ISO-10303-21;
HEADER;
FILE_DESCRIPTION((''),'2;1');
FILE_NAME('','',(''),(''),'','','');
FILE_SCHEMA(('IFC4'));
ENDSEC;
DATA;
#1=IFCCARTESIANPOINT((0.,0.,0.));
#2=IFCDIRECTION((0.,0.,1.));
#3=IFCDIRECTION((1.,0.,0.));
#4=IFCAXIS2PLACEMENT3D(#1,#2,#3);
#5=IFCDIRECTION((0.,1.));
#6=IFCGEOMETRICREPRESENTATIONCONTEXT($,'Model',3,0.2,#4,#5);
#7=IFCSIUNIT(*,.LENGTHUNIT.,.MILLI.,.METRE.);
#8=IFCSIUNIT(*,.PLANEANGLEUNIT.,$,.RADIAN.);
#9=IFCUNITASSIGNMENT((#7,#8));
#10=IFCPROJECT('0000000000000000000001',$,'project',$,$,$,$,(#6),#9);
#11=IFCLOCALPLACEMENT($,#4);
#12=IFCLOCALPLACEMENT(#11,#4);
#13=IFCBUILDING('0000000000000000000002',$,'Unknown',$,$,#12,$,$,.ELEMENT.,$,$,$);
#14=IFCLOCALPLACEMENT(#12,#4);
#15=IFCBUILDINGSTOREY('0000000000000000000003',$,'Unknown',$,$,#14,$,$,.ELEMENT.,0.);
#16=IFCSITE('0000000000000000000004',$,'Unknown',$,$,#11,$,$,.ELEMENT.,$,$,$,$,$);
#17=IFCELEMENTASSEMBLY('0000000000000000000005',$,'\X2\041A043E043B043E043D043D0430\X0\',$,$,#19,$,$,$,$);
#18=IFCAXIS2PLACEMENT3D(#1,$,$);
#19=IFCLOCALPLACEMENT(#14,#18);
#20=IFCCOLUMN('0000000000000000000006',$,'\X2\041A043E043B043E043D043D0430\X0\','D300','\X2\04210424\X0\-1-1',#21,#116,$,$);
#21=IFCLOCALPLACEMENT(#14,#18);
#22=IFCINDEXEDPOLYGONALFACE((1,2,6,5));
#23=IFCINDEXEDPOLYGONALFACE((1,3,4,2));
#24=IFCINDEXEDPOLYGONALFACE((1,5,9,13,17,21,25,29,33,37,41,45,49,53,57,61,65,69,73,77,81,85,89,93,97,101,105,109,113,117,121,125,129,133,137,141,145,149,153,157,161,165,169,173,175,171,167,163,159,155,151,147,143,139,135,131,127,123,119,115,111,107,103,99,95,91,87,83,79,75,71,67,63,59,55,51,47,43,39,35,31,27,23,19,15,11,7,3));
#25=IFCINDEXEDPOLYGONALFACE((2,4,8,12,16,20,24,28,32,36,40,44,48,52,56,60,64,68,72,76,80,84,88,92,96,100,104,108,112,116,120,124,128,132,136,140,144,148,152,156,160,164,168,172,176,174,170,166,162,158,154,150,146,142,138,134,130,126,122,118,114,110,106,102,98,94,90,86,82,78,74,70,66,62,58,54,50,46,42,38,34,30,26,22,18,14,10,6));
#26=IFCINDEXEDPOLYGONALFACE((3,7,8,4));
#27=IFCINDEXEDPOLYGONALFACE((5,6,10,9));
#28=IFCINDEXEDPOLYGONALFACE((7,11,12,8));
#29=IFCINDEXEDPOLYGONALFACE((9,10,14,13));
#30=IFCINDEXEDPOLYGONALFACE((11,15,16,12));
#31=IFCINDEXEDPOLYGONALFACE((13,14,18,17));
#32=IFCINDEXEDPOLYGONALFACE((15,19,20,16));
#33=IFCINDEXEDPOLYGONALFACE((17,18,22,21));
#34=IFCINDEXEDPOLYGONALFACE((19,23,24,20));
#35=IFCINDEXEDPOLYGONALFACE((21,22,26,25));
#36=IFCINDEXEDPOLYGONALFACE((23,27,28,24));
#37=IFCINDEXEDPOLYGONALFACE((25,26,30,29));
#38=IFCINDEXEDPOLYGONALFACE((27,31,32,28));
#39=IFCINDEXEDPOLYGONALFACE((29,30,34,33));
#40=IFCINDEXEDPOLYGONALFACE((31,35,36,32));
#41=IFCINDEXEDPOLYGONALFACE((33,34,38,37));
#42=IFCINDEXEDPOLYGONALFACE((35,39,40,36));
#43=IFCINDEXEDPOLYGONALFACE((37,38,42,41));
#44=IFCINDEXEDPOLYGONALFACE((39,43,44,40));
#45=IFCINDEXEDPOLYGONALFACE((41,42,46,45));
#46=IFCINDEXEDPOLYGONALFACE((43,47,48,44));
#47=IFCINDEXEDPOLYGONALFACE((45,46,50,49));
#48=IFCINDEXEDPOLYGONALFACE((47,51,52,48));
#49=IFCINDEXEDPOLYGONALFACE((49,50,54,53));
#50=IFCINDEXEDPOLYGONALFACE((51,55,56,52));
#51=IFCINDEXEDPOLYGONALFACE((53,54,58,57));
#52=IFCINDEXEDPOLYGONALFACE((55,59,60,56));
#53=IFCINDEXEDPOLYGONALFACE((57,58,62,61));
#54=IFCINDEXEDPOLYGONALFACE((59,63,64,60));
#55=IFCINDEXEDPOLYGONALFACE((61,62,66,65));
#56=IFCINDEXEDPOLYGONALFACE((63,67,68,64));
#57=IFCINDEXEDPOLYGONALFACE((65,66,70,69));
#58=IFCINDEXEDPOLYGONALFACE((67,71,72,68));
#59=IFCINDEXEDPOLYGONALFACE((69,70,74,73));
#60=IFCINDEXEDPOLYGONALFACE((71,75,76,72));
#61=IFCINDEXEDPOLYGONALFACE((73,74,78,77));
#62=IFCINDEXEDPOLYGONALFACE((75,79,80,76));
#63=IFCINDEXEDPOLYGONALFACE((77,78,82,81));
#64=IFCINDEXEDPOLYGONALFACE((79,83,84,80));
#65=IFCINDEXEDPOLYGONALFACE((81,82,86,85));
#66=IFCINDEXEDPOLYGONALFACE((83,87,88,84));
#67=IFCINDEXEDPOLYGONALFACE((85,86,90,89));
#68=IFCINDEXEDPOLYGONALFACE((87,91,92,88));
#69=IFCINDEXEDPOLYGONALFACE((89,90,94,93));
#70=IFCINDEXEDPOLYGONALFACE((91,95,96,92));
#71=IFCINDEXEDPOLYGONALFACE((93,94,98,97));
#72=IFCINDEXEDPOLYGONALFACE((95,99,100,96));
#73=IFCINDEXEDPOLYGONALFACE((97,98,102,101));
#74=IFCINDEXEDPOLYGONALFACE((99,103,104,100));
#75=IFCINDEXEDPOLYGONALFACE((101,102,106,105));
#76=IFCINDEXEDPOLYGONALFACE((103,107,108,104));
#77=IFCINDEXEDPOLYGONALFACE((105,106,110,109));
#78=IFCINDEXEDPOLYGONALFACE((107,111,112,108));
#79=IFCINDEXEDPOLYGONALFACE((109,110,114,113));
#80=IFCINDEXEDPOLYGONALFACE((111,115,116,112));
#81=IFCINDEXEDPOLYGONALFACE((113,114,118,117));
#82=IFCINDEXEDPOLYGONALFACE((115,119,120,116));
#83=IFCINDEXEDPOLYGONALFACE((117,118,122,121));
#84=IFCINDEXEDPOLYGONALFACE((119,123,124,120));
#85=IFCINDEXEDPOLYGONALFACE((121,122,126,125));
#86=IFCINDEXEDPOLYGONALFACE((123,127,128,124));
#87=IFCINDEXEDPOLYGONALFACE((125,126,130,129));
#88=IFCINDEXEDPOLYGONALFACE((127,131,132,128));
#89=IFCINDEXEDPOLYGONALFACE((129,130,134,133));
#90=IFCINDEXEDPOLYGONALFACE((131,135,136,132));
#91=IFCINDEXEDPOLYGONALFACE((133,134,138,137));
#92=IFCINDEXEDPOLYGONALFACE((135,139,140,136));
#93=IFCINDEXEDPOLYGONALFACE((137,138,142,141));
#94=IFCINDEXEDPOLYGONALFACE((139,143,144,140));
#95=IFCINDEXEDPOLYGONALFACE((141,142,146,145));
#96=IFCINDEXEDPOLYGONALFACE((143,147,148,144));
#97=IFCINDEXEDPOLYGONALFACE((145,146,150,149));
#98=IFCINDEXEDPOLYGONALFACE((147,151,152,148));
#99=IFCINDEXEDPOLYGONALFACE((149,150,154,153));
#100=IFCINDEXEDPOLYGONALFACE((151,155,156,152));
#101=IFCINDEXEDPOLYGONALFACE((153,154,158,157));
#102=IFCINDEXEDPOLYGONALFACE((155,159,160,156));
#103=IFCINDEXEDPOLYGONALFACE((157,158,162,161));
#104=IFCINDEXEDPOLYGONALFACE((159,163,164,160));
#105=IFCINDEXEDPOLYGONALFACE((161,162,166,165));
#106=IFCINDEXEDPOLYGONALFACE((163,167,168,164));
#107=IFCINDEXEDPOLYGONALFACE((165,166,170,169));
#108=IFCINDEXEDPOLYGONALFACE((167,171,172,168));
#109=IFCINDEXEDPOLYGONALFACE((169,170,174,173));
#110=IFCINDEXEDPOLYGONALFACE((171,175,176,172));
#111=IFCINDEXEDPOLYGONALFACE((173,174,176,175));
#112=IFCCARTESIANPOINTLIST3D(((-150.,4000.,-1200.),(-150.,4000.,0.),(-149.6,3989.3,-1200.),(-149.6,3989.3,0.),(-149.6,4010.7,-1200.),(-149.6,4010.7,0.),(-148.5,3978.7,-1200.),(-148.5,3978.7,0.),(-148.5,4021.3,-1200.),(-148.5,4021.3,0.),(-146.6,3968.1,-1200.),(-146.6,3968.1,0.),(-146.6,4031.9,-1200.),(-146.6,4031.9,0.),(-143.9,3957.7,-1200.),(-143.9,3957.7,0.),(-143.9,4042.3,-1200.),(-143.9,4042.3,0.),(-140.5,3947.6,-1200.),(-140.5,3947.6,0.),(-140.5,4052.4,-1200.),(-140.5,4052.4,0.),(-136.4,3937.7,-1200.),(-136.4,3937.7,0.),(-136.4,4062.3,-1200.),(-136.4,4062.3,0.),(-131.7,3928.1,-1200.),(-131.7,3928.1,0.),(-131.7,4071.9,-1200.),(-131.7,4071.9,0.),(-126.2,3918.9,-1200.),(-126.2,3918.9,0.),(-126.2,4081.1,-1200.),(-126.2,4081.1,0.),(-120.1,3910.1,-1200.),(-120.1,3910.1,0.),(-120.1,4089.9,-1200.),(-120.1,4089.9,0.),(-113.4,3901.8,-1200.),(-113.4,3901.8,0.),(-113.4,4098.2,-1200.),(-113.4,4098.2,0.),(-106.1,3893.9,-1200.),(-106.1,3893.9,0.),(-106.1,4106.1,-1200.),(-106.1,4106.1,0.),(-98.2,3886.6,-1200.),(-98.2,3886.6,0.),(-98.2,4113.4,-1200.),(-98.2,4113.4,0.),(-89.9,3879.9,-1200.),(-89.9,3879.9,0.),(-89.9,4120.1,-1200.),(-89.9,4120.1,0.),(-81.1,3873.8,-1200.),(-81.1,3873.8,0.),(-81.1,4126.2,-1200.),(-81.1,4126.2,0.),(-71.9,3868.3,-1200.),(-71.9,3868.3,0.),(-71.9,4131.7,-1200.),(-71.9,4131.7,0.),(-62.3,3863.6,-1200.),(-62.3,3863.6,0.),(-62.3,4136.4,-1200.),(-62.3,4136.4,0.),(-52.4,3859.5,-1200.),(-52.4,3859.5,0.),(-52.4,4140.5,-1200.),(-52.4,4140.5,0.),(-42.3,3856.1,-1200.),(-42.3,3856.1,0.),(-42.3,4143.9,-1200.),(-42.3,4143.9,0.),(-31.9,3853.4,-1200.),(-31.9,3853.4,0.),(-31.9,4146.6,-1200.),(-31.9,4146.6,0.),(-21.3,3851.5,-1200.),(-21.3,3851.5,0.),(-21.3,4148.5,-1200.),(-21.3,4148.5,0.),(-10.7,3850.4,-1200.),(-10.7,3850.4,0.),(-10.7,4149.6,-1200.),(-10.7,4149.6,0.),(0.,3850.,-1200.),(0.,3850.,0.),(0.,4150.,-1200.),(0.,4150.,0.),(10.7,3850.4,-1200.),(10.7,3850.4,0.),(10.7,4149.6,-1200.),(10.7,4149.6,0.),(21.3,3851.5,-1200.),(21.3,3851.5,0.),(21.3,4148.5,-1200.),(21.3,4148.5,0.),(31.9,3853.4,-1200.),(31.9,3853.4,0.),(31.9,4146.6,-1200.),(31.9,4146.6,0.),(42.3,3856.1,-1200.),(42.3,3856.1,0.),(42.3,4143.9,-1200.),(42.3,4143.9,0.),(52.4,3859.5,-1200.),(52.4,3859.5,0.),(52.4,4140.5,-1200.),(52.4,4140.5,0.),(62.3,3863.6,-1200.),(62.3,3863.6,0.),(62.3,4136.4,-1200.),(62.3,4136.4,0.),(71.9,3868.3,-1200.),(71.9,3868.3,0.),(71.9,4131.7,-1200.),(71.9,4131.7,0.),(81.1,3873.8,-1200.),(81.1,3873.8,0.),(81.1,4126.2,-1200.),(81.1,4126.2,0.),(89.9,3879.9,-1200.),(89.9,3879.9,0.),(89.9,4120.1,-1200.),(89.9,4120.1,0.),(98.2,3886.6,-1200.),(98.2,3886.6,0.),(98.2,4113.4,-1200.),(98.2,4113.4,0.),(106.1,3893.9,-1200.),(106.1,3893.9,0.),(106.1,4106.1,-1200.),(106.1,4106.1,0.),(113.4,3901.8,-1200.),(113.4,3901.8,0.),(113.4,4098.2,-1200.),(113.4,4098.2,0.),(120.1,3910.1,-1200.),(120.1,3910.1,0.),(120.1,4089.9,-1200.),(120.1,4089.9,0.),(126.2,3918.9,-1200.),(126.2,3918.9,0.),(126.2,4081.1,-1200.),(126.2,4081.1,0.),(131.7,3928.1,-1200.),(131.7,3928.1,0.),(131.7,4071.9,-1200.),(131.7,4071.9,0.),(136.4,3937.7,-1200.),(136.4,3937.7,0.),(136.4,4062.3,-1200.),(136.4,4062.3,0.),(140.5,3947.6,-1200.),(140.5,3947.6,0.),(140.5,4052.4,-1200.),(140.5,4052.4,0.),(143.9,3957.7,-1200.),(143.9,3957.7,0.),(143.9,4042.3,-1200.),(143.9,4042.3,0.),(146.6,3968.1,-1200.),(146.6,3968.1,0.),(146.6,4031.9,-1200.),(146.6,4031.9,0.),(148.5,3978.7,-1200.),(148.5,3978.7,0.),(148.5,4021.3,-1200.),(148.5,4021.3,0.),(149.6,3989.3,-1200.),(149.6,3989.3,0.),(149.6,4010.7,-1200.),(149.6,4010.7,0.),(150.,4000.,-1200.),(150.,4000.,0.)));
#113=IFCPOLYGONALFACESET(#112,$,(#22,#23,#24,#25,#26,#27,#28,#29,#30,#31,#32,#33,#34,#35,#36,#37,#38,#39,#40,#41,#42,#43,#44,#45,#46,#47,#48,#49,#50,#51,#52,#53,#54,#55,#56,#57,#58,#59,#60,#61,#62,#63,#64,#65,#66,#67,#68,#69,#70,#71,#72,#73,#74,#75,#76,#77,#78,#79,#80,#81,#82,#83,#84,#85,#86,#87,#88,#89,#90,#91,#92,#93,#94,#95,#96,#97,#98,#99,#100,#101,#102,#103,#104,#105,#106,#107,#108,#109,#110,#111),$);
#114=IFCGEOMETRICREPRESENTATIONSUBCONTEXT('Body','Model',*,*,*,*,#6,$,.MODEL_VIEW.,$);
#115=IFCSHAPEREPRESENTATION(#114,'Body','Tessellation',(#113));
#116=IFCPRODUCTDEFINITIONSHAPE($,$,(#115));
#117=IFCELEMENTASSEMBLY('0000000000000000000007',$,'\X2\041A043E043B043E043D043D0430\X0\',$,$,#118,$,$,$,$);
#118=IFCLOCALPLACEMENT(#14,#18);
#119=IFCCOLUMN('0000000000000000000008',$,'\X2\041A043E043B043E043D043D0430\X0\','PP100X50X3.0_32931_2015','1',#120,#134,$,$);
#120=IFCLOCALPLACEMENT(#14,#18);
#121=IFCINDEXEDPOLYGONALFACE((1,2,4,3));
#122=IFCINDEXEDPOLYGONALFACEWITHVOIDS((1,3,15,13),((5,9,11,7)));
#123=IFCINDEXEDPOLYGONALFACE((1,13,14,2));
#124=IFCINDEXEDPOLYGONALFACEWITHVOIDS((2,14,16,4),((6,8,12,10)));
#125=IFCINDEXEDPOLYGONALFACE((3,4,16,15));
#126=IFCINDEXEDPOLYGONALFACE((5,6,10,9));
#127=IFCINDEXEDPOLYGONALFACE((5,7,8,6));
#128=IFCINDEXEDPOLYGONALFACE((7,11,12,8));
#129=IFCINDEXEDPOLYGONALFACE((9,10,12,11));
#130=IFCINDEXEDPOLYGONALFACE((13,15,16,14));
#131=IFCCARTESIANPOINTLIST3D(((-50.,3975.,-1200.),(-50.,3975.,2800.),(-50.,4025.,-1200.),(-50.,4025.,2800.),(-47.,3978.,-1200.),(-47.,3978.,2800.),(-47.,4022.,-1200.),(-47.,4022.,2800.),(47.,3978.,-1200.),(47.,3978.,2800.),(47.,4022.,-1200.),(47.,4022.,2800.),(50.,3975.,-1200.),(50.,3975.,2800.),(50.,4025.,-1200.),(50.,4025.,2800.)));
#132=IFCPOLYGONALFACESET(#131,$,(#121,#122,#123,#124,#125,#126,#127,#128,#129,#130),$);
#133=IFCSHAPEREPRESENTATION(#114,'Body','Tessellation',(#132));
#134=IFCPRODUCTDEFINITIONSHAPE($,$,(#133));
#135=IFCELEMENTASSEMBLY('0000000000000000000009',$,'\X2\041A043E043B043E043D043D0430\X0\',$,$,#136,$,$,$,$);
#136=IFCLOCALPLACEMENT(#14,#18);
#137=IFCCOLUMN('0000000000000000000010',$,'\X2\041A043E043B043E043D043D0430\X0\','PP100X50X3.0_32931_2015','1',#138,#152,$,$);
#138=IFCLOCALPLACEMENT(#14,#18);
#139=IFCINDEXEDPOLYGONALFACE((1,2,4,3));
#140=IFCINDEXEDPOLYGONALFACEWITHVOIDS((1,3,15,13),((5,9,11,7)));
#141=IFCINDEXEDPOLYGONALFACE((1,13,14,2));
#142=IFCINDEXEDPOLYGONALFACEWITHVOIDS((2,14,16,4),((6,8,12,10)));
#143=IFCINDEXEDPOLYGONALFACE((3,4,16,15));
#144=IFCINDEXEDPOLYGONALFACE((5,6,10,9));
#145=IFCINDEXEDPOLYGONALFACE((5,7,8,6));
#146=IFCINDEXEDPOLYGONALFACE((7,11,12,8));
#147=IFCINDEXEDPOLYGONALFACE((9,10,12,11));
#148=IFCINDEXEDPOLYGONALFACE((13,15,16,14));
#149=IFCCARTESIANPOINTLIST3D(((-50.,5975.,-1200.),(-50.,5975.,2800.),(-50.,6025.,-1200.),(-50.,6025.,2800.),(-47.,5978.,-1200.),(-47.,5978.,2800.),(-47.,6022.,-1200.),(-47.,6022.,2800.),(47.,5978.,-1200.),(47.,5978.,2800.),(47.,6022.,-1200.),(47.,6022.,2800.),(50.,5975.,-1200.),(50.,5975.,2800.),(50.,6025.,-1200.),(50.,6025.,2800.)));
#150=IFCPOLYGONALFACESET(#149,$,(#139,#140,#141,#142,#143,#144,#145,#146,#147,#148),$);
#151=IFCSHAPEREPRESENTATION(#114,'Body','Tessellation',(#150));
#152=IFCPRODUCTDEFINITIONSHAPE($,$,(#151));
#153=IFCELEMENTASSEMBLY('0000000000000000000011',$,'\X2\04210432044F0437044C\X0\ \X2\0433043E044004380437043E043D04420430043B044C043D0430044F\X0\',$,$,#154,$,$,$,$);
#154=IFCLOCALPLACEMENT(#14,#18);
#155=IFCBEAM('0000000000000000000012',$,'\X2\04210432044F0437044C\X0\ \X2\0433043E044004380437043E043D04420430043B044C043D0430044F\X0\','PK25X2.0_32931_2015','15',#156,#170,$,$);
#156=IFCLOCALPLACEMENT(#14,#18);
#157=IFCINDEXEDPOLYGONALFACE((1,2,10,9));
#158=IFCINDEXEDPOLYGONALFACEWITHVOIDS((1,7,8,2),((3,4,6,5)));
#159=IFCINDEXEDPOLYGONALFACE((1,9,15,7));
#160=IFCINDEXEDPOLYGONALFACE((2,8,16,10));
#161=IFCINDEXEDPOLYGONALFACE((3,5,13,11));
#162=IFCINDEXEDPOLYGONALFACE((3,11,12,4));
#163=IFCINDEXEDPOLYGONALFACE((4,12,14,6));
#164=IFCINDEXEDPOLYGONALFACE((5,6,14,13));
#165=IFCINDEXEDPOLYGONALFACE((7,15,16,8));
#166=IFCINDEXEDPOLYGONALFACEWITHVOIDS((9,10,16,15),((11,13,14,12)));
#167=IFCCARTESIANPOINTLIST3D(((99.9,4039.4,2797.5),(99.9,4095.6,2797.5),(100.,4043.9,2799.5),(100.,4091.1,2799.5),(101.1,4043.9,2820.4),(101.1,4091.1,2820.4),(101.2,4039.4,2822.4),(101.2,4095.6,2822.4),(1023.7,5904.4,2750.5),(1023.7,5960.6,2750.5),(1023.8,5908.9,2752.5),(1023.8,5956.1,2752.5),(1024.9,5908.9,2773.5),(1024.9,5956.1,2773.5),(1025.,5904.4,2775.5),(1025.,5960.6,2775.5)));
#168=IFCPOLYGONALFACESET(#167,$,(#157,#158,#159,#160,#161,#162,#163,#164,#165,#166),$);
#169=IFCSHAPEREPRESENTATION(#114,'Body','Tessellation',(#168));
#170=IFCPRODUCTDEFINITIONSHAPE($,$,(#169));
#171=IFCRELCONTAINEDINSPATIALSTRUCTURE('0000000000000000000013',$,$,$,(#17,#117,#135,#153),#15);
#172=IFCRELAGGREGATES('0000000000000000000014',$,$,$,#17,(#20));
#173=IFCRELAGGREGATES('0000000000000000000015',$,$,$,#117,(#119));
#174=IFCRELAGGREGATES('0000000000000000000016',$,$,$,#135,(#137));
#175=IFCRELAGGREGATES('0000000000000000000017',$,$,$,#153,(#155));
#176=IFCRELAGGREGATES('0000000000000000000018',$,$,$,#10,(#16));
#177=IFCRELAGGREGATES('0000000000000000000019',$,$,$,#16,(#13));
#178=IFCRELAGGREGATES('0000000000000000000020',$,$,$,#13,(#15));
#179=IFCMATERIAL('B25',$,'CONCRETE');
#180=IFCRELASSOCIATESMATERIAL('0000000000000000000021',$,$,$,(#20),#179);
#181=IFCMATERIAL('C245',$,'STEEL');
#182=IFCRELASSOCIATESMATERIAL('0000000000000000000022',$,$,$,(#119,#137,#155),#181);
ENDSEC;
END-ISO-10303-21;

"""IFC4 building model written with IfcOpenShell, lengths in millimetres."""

from ifc_helpers import new_model, si_unit, direction, frame, origin_with_axes, place, context, subcontext, project, spatial, line, indexed_curve, outline, extrude, material, element, aggregate, save


model = new_model("IFC4")

# Units and contexts
model_context = context("Model", 3, precision=0.2, world=origin_with_axes(), true_north=direction((0.0, 1.0)))
body_context = subcontext(model_context, "Body", "Model", "MODEL_VIEW")
ifc_project = project(units=[si_unit("LENGTHUNIT", "METRE", prefix="MILLI"), si_unit("PLANEANGLEUNIT", "RADIAN")], contexts=[model_context])

# Site, building, storey
site_placement = place(None, origin_with_axes())
site = spatial("IfcSite", under=ifc_project, at=site_placement, Name="Unknown", CompositionType="ELEMENT")
building_placement = place(site_placement, origin_with_axes())
building = spatial("IfcBuilding", under=site, at=building_placement, Name="Unknown", CompositionType="ELEMENT")
storey_placement = place(building_placement, origin_with_axes())
storey = spatial("IfcBuildingStorey", under=building, at=storey_placement, Name="Unknown", CompositionType="ELEMENT", Elevation=0.0)

# Element assemblies, columns
ifc_material_1 = material(Name="B25", Category="CONCRETE")
assembly_1_placement = place(storey_placement, frame((0.0, 4000.0, -1200.0), z_axis=(-1.0, 0.0, 0.0), x_axis=(0.0, 0.0, 1.0)))
assembly_1 = element("IfcElementAssembly", 1, at=assembly_1_placement, inside=storey, Name="Колонна")
column_1_placement = place(assembly_1_placement, origin_with_axes())
column_1 = element("IfcColumn", 2, at=column_1_placement, material=ifc_material_1, Name="Колонна", Description="D300", ObjectType="СФ-1-1", context=body_context, shape_type="SolidModel", body=[
    extrude(outline(indexed_curve([(150.0, 0.0), (149.6, 10.7), (148.5, 21.3), (146.6, 31.9), (143.9, 42.3), (140.5, 52.4), (136.4, 62.3), (131.7, 71.9), (126.2, 81.1), (120.1, 89.9), (113.4, 98.2), (106.1, 106.1), (98.2, 113.4), (89.9, 120.1), (81.1, 126.2), (71.9, 131.7), (62.3, 136.4), (52.4, 140.5), (42.3, 143.9), (31.9, 146.6), (21.3, 148.5), (10.7, 149.6), (0.0, 150.0), (-10.7, 149.6), (-21.3, 148.5), (-31.9, 146.6), (-42.3, 143.9), (-52.4, 140.5), (-62.3, 136.4), (-71.9, 131.7), (-81.1, 126.2), (-89.9, 120.1), (-98.2, 113.4), (-106.1, 106.1), (-113.4, 98.2), (-120.1, 89.9), (-126.2, 81.1), (-131.7, 71.9), (-136.4, 62.3), (-140.5, 52.4), (-143.9, 42.3), (-146.6, 31.9), (-148.5, 21.3), (-149.6, 10.7), (-150.0, 0.0), (-149.6, -10.7), (-148.5, -21.3), (-146.6, -31.9), (-143.9, -42.3), (-140.5, -52.4), (-136.4, -62.3), (-131.7, -71.9), (-126.2, -81.1), (-120.1, -89.9), (-113.4, -98.2), (-106.1, -106.1), (-98.2, -113.4), (-89.9, -120.1), (-81.1, -126.2), (-71.9, -131.7), (-62.3, -136.4), (-52.4, -140.5), (-42.3, -143.9), (-31.9, -146.6), (-21.3, -148.5), (-10.7, -149.6), (0.0, -150.0), (10.7, -149.6), (21.3, -148.5), (31.9, -146.6), (42.3, -143.9), (52.4, -140.5), (62.3, -136.4), (71.9, -131.7), (81.1, -126.2), (89.9, -120.1), (98.2, -113.4), (106.1, -106.1), (113.4, -98.2), (120.1, -89.9), (126.2, -81.1), (131.7, -71.9), (136.4, -62.3), (140.5, -52.4), (143.9, -42.3), (146.6, -31.9), (148.5, -21.3), (149.6, -10.7)], segments=[line(1, 2, 3, 4, 5, 6, 7, 8, 9, 10, 11, 12, 13, 14, 15, 16, 17, 18, 19, 20, 21, 22, 23, 24, 25, 26, 27, 28, 29, 30, 31, 32, 33, 34, 35, 36, 37, 38, 39, 40, 41, 42, 43, 44, 45, 46, 47, 48, 49, 50, 51, 52, 53, 54, 55, 56, 57, 58, 59, 60, 61, 62, 63, 64, 65, 66, 67, 68, 69, 70, 71, 72, 73, 74, 75, 76, 77, 78, 79, 80, 81, 82, 83, 84, 85, 86, 87, 88, 1)])), frame((0.0, 0.0, 0.0), z_axis=(-1.0, 0.0, 0.0), x_axis=(0.0, 0.0, 1.0)), (0.0, 0.0, -1.0), 1200.0),
])
aggregate(assembly_1, [column_1])
assembly_2_placement = place(storey_placement, frame((0.0, 4000.0, -1200.0), z_axis=(0.0, -1.0, 0.0), x_axis=(0.0, 0.0, 1.0)))
assembly_2 = element("IfcElementAssembly", 3, at=assembly_2_placement, inside=storey, Name="Колонна")
ifc_material_2 = material(Name="C245", Category="STEEL")
column_2_placement = place(assembly_2_placement, origin_with_axes())
column_2 = element("IfcColumn", 4, at=column_2_placement, material=ifc_material_2, Name="Колонна", Description="PP100X50X3.0_32931_2015", ObjectType="1", context=body_context, shape_type="SolidModel", body=[
    extrude(outline(indexed_curve([(-25.0, -50.0), (25.0, -50.0), (25.0, 50.0), (-25.0, 50.0)], segments=[line(1, 2, 3, 4, 1)]), holes=[indexed_curve([(-22.0, -47.0), (-22.0, 47.0), (22.0, 47.0), (22.0, -47.0)], segments=[line(1, 2, 3, 4, 1)])]), frame((0.0, 0.0, 0.0), z_axis=(-1.0, 0.0, 0.0), x_axis=(0.0, 0.0, 1.0)), (0.0, 0.0, -1.0), 4000.0),
])
aggregate(assembly_2, [column_2])
assembly_3_placement = place(storey_placement, frame((0.0, 6000.0, -1200.0), z_axis=(0.0, -1.0, 0.0), x_axis=(0.0, 0.0, 1.0)))
assembly_3 = element("IfcElementAssembly", 5, at=assembly_3_placement, inside=storey, Name="Колонна")
column_3_placement = place(assembly_3_placement, origin_with_axes())
column_3 = element("IfcColumn", 6, at=column_3_placement, material=ifc_material_2, Name="Колонна", Description="PP100X50X3.0_32931_2015", ObjectType="1", context=body_context, shape_type="SolidModel", body=[
    extrude(outline(indexed_curve([(-25.0, -50.0), (25.0, -50.0), (25.0, 50.0), (-25.0, 50.0)], segments=[line(1, 2, 3, 4, 1)]), holes=[indexed_curve([(-22.0, -47.0), (-22.0, 47.0), (22.0, 47.0), (22.0, -47.0)], segments=[line(1, 2, 3, 4, 1)])]), frame((0.0, 0.0, 0.0), z_axis=(-1.0, 0.0, 0.0), x_axis=(0.0, 0.0, 1.0)), (0.0, 0.0, -1.0), 4000.0),
])
aggregate(assembly_3, [column_3])

# Element assembly, beam, voiding features
assembly_4_placement = place(storey_placement, frame((73.4, 4012.6, 2811.3), z_axis=(0.894709, -0.444326, -0.045494), x_axis=(0.443753, 0.895865, -0.022564)))
assembly_4 = element("IfcElementAssembly", 7, at=assembly_4_placement, inside=storey, Name="Связь горизонтальная")
beam_1_placement = place(assembly_4_placement, origin_with_axes())
beam_1 = element("IfcBeam", 8, at=beam_1_placement, material=ifc_material_2, Name="Связь горизонтальная", Description="PK25X2.0_32931_2015", ObjectType="15", context=body_context, shape_type="SolidModel", body=[
    extrude(outline(indexed_curve([(-12.5, -12.5), (12.5, -12.5), (12.5, 12.5), (-12.5, 12.5)], segments=[line(1, 2, 3, 4, 1)]), holes=[indexed_curve([(-10.5, -10.5), (-10.5, 10.5), (10.5, 10.5), (10.5, -10.5)], segments=[line(1, 2, 3, 4, 1)])]), frame((0.0, 0.0, 0.0), z_axis=(-1.0, 0.0, 0.0), x_axis=(0.0, 0.0, 1.0)), (0.0, 0.0, -1.0), 2204.4),
])
voiding_feature_1_placement = place(beam_1_placement, frame((1204.9, 12.5, 493.2), z_axis=(0.444326, 0.0, 0.895865), x_axis=(0.895865, 0.0, -0.444326)))
element("IfcVoidingFeature", 9, at=voiding_feature_1_placement, cuts=beam_1, Name="CUT_BEAM", ObjectType="(?)", PredefinedType="HOLE", context=body_context, shape_type="SolidModel", body=[
    extrude(outline(indexed_curve([(-25.0, -25.0), (25.0, -25.0), (25.0, 25.0), (-25.0, 25.0)], segments=[line(1, 2, 3, 4, 1)])), frame((0.0, 0.0, 0.0), z_axis=(-1.0, 0.0, 0.0), x_axis=(0.0, 0.0, 1.0)), (0.0, 0.0, -1.0), 2220.1),
])
voiding_feature_2_placement = place(beam_1_placement, frame((-989.4, 12.5, 493.2), z_axis=(0.444326, 0.0, 0.895865), x_axis=(0.895865, 0.0, -0.444326)))
element("IfcVoidingFeature", 10, at=voiding_feature_2_placement, cuts=beam_1, Name="CUT_BEAM", ObjectType="(?)", PredefinedType="HOLE", context=body_context, shape_type="SolidModel", body=[
    extrude(outline(indexed_curve([(-25.0, -25.0), (25.0, -25.0), (25.0, 25.0), (-25.0, 25.0)], segments=[line(1, 2, 3, 4, 1)])), frame((0.0, 0.0, 0.0), z_axis=(-1.0, 0.0, 0.0), x_axis=(0.0, 0.0, 1.0)), (0.0, 0.0, -1.0), 2220.1),
])
aggregate(assembly_4, [beam_1])

save(model, "model.ifc")
